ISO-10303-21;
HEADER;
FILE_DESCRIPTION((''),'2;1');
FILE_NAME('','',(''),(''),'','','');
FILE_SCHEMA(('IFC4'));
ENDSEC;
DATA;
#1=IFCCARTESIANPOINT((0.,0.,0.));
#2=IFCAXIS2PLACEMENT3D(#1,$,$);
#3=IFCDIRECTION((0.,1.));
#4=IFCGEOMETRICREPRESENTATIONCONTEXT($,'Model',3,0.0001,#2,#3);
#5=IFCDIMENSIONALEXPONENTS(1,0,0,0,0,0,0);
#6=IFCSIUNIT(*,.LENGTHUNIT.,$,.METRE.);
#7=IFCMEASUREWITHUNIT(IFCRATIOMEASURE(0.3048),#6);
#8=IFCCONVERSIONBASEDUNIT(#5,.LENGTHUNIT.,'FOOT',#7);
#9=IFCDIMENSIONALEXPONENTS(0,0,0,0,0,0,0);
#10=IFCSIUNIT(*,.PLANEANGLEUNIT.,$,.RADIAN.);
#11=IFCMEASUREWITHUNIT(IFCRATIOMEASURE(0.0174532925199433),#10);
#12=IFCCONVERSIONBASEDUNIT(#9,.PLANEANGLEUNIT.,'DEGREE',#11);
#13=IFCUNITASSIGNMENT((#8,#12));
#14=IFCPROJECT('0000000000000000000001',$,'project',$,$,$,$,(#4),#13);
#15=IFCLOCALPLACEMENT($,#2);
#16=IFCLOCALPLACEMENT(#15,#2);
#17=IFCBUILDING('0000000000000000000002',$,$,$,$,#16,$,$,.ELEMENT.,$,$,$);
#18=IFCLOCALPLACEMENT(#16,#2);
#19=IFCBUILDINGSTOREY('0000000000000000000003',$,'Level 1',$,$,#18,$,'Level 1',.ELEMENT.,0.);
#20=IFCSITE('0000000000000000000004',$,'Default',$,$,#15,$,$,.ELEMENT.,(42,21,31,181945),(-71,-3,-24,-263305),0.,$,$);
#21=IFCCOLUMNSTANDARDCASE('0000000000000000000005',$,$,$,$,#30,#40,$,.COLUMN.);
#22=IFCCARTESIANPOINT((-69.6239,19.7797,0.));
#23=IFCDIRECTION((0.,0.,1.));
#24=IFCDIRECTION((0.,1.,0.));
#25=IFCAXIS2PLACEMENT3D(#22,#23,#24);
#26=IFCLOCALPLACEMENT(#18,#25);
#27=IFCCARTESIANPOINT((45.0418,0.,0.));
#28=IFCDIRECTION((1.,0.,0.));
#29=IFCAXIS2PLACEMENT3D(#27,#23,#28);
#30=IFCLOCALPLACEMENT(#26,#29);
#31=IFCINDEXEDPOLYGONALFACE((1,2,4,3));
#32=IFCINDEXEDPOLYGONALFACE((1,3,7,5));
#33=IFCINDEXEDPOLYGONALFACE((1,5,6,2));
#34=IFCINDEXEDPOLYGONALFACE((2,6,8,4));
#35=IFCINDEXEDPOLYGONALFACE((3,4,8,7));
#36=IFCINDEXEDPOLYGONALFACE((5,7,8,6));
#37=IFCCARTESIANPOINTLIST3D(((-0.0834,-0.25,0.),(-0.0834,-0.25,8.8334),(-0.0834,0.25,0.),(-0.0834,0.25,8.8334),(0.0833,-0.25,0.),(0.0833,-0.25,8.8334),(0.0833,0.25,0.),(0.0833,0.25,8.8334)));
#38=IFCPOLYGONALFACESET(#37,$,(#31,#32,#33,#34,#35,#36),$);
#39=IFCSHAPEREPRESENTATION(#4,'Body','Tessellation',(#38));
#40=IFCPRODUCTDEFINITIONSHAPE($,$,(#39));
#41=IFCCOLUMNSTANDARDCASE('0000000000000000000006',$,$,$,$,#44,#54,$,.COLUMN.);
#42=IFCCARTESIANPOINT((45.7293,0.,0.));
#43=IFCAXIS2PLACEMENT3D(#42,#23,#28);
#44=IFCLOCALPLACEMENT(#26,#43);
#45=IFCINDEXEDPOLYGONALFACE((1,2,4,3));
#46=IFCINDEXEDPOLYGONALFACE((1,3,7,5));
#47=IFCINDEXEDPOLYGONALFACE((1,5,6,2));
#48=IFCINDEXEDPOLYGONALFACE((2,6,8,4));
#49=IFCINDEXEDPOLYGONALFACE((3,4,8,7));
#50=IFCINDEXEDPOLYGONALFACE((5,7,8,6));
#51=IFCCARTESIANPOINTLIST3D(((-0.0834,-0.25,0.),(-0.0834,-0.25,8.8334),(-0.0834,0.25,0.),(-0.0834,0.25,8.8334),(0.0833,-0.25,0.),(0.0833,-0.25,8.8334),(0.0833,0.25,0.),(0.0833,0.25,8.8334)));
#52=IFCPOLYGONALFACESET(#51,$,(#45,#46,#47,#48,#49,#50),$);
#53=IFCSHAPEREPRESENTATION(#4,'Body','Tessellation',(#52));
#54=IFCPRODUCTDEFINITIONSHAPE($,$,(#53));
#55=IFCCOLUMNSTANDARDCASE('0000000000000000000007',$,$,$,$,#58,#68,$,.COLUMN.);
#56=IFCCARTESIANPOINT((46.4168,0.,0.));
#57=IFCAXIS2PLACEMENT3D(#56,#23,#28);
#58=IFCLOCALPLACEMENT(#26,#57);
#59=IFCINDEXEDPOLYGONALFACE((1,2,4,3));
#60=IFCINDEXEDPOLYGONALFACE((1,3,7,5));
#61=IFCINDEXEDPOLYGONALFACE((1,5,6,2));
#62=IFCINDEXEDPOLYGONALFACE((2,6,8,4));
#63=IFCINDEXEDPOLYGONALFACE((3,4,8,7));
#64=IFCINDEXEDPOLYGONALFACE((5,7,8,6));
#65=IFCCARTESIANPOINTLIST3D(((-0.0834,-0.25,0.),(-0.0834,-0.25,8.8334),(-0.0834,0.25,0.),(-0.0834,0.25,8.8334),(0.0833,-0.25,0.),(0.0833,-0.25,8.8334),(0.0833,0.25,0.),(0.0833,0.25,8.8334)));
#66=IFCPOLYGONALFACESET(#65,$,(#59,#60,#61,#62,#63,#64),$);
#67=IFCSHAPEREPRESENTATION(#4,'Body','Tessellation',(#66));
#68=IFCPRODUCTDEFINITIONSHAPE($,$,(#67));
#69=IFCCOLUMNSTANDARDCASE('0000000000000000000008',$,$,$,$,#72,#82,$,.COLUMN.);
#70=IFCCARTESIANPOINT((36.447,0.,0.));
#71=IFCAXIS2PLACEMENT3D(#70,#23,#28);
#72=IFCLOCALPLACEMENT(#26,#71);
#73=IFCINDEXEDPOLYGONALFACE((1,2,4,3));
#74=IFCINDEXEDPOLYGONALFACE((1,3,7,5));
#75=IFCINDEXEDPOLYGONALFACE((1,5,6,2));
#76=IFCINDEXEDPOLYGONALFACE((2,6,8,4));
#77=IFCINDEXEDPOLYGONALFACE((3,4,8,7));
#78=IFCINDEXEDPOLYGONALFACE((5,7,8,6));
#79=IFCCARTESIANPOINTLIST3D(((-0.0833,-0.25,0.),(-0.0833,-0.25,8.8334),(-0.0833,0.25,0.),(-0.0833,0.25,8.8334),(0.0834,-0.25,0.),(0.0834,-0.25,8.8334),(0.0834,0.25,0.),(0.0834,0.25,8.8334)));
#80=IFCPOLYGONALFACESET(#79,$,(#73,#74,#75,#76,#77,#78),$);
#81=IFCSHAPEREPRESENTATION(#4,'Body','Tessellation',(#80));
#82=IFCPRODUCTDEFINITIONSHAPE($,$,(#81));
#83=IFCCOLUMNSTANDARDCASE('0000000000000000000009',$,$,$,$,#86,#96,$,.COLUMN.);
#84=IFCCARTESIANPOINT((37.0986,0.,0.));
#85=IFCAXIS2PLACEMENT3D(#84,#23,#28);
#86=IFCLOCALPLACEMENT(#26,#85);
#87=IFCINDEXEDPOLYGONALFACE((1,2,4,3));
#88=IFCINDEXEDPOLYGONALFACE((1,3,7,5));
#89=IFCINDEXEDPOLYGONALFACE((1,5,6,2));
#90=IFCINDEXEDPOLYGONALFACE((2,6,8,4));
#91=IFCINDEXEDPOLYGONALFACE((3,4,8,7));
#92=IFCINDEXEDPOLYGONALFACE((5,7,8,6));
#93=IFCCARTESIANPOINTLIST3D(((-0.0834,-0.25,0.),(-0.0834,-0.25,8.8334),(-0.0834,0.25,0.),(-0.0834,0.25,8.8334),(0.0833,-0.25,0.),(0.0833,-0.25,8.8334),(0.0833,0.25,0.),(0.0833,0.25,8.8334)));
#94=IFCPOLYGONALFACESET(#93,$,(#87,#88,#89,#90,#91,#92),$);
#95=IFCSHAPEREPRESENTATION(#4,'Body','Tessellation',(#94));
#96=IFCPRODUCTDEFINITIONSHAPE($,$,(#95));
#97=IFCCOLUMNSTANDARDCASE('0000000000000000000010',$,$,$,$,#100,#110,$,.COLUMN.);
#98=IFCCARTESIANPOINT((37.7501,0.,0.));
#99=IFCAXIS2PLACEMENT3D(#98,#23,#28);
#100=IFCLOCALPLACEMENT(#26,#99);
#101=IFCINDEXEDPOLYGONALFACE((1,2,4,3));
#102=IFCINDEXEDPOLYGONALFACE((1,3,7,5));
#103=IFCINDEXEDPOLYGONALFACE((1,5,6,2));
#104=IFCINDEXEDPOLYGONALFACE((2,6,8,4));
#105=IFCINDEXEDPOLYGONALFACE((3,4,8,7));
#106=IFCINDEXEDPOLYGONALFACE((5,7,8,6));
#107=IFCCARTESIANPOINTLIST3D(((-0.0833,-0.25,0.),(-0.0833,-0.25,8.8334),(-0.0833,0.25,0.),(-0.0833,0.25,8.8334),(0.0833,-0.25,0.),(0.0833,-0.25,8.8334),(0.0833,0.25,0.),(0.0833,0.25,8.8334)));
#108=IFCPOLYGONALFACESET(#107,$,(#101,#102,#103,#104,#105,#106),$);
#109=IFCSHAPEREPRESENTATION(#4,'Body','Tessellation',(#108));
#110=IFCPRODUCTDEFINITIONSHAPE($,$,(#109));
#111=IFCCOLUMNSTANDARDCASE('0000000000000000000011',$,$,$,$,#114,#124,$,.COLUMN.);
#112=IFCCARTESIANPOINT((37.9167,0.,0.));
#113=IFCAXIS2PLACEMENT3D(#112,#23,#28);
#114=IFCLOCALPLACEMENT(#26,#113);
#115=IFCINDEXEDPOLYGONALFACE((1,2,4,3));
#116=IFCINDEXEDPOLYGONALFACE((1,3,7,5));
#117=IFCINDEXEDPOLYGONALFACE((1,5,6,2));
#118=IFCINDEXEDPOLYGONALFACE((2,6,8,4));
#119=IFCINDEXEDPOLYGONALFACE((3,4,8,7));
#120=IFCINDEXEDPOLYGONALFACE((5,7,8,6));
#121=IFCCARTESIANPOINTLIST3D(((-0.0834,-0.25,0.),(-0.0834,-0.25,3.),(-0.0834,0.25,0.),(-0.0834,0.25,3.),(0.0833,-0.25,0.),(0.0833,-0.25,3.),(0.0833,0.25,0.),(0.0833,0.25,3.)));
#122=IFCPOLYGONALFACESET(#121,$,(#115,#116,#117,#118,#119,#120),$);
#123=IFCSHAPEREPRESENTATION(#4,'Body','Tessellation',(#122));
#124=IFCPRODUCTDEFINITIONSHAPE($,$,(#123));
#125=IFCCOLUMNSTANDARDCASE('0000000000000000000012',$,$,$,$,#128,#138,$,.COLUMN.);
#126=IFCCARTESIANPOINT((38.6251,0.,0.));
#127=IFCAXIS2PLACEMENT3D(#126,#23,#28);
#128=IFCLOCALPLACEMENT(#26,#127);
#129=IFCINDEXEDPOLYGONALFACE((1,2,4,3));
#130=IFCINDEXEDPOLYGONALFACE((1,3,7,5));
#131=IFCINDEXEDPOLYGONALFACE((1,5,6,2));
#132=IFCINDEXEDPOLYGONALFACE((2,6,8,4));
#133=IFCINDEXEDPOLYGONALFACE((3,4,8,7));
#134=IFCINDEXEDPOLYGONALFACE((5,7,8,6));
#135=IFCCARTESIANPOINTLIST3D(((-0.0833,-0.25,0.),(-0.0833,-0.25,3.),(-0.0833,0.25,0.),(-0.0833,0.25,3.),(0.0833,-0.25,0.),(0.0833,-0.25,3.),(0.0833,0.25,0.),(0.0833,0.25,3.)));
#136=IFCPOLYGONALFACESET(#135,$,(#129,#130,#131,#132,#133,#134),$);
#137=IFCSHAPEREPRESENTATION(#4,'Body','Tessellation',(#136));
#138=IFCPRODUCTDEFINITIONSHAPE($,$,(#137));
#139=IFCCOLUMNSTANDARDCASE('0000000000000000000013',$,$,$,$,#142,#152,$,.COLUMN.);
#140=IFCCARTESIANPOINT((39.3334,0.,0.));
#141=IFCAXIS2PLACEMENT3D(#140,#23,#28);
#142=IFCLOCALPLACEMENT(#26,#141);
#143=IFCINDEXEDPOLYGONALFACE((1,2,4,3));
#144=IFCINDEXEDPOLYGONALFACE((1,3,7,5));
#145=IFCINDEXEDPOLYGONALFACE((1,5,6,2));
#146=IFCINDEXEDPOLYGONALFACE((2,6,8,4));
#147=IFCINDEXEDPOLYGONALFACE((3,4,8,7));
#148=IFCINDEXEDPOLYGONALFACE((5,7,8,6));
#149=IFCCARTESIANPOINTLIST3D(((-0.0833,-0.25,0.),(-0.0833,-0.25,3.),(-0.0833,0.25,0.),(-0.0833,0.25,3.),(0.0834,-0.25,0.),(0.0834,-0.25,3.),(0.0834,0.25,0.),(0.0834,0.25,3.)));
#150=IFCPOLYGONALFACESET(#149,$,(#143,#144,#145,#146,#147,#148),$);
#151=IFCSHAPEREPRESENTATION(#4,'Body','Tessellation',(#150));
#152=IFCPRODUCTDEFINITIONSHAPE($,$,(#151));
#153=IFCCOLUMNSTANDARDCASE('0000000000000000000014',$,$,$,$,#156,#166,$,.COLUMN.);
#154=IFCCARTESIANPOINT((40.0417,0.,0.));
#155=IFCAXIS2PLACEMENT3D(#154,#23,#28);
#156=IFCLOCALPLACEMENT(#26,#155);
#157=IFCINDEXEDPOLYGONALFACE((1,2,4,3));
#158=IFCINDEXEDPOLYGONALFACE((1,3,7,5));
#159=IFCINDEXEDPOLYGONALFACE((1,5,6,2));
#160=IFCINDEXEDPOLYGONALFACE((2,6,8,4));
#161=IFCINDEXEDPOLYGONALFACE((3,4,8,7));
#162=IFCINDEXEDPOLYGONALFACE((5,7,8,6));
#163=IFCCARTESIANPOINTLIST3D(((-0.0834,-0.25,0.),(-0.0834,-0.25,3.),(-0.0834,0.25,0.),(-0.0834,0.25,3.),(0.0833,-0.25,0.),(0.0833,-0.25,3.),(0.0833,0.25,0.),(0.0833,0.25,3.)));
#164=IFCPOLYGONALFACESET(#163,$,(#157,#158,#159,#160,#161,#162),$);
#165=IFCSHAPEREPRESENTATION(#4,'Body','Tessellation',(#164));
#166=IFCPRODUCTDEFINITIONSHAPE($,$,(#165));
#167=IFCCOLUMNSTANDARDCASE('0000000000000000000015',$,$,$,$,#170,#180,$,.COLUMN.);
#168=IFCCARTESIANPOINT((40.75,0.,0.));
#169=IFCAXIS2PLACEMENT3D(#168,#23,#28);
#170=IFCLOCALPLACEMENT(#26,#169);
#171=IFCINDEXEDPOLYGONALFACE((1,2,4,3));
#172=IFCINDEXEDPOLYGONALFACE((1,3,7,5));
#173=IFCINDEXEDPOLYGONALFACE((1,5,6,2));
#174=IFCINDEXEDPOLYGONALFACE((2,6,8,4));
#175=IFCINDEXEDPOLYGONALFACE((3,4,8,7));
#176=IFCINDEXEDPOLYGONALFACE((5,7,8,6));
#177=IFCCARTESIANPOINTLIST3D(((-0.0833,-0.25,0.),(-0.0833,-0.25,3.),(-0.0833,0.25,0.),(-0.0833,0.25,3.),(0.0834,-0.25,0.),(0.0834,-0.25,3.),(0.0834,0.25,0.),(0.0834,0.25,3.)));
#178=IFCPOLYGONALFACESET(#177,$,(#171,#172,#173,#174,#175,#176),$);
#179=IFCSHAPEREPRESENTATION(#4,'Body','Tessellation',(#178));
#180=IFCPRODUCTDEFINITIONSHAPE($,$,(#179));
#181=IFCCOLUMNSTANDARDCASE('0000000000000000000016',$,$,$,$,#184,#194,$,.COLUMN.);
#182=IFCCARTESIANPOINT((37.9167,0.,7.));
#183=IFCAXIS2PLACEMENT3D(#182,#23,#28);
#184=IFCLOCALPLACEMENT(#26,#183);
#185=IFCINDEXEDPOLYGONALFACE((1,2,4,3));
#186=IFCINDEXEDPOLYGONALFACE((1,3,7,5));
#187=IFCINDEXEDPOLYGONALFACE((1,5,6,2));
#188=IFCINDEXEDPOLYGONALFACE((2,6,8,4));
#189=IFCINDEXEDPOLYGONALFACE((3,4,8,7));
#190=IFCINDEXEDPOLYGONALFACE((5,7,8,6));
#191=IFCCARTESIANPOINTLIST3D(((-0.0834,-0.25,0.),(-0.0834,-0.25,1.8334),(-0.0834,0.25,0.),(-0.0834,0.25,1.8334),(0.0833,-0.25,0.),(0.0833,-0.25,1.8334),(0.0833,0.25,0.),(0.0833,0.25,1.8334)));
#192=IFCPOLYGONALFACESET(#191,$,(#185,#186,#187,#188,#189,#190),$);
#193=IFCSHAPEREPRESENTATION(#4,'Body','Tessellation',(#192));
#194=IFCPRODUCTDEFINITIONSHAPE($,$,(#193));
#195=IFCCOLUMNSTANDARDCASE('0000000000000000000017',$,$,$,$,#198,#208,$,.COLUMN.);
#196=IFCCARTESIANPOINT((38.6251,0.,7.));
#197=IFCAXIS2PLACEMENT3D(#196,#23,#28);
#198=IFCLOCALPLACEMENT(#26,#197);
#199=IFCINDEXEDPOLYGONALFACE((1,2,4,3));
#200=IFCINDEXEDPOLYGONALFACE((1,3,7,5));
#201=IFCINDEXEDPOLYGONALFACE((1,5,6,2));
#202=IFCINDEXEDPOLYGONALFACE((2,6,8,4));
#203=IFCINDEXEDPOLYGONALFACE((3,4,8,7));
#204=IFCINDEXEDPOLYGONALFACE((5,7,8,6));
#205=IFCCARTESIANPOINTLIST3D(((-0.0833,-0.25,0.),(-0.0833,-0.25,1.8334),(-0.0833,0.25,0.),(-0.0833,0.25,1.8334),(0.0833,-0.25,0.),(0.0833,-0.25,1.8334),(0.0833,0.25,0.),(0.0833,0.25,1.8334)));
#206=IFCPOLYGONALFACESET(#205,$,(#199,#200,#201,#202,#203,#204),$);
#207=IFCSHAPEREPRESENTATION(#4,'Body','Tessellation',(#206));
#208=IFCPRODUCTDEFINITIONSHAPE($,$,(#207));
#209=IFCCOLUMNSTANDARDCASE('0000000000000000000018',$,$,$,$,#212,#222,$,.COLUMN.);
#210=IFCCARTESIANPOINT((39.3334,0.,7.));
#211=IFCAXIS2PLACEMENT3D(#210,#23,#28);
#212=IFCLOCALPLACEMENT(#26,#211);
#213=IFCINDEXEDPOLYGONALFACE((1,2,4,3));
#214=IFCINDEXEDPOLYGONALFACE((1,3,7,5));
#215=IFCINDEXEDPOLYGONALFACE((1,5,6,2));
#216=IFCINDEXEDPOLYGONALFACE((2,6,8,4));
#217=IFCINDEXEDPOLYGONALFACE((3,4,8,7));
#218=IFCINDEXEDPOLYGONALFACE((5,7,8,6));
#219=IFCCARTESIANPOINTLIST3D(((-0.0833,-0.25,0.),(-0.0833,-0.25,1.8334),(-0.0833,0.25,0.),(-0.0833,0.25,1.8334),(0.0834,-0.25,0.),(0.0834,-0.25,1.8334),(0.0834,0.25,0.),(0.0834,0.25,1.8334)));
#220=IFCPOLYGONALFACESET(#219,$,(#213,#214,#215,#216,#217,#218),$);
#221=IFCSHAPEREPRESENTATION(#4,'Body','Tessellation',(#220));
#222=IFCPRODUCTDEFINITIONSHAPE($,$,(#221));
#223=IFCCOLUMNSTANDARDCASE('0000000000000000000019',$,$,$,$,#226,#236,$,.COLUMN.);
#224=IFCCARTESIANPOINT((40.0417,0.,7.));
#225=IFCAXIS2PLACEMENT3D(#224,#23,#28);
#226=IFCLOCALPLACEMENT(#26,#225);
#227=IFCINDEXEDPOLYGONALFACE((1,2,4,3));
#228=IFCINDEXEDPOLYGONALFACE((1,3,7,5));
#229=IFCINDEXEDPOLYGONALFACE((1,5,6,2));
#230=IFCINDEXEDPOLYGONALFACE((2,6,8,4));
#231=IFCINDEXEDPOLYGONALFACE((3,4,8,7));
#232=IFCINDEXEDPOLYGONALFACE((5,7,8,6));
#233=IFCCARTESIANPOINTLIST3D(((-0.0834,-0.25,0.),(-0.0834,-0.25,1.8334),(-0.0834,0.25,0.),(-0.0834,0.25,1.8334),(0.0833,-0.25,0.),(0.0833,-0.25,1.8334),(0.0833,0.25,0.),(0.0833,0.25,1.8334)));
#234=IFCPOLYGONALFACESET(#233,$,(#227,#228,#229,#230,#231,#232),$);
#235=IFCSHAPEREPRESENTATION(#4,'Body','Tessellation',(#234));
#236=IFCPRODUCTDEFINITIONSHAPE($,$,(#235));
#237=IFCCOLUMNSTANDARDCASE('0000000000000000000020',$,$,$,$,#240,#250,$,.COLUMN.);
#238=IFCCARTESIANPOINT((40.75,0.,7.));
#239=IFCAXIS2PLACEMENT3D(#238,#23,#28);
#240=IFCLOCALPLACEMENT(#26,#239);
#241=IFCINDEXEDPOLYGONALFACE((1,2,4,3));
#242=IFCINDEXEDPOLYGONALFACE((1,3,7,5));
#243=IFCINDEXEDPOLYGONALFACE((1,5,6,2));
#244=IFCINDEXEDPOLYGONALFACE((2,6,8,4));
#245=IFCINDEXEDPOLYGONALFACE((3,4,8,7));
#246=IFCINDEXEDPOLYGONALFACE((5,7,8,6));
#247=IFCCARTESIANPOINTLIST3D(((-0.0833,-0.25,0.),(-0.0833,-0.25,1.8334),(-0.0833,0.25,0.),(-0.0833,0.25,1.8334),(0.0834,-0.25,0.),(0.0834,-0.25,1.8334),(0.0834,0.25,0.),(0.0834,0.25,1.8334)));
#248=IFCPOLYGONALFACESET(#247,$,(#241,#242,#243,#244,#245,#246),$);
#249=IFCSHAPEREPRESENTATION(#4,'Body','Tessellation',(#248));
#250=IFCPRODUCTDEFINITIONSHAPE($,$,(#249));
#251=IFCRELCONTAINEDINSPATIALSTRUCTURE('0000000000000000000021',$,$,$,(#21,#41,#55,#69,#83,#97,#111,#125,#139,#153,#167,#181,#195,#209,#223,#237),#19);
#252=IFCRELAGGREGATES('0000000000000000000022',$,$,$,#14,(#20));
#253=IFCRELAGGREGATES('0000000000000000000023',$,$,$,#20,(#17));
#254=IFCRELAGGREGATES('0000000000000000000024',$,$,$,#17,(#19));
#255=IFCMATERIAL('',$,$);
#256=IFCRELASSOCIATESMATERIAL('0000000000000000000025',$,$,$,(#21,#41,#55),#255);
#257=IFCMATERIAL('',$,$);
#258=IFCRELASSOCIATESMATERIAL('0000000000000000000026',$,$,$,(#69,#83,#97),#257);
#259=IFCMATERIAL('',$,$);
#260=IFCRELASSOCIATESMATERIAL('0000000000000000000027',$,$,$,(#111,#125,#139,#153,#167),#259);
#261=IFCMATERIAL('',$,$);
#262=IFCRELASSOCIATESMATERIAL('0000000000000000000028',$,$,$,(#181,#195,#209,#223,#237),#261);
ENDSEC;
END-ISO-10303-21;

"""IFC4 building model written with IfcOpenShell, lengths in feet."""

from ifc_helpers import new_model, entity, si_unit, converted_unit, direction, frame, origin, place, context, project, spatial, rectangle, extrude, material, element, save


model = new_model("IFC4")

# Units and contexts
model_context = context("Model", 3, precision=0.0001, world=origin(), true_north=direction((0.0, 1.0)))
ifc_project = project(units=[converted_unit("LENGTHUNIT", "FOOT", entity("IfcRatioMeasure", 0.3048), si_unit("LENGTHUNIT", "METRE"), dimensions=[1, 0, 0, 0, 0, 0, 0]), converted_unit("PLANEANGLEUNIT", "DEGREE", entity("IfcRatioMeasure", 0.0174532925199433), si_unit("PLANEANGLEUNIT", "RADIAN"), dimensions=[0, 0, 0, 0, 0, 0, 0])], contexts=[model_context])

# Site, building, storey
site_placement = place(None, origin())
site = spatial("IfcSite", under=ifc_project, at=site_placement, Name="Default", CompositionType="ELEMENT", RefLatitude=(42, 21, 31, 181945), RefLongitude=(-71, -3, -24, -263305), RefElevation=0.0)
building_placement = place(site_placement, origin())
building = spatial("IfcBuilding", under=site, at=building_placement, CompositionType="ELEMENT")
storey_placement = place(building_placement, origin())
storey = spatial("IfcBuildingStorey", under=building, at=storey_placement, Name="Level 1", LongName="Level 1", CompositionType="ELEMENT", Elevation=0.0)

# Columns
ifc_material_1 = material(Name="")
placement_1 = place(storey_placement, frame((-69.6239, 19.7797, 0.0), z_axis=(0.0, 0.0, 1.0), x_axis=(0.0, 1.0, 0.0)))
for number, where, z_axis, x_axis in (
    (1, (45.0418, 0.0, 0.0), (0.0, 0.0, 1.0), (1.0, 0.0, 0.0)),
    (2, (45.7293, 0.0, 0.0), (0.0, 0.0, 1.0), (1.0, 0.0, 0.0)),
    (3, (46.4168, 0.0, 0.0), (0.0, 0.0, 1.0), (1.0, 0.0, 0.0)),
):
    element("IfcColumnStandardCase", number, at=place(placement_1, frame(where, z_axis=z_axis, x_axis=x_axis)), inside=storey, material=ifc_material_1, PredefinedType="COLUMN", context=model_context, shape_type="SweptSolid", body=[
        extrude(rectangle(XDim=0.1667, YDim=0.5), origin(), (0.0, 0.0, 1.0), 8.8334),
    ])
ifc_material_2 = material(Name="")
for number, where, z_axis, x_axis in (
    (4, (36.447, 0.0, 0.0), (0.0, 0.0, 1.0), (1.0, 0.0, 0.0)),
    (5, (37.0986, 0.0, 0.0), (0.0, 0.0, 1.0), (1.0, 0.0, 0.0)),
    (6, (37.7501, 0.0, 0.0), (0.0, 0.0, 1.0), (1.0, 0.0, 0.0)),
):
    element("IfcColumnStandardCase", number, at=place(placement_1, frame(where, z_axis=z_axis, x_axis=x_axis)), inside=storey, material=ifc_material_2, PredefinedType="COLUMN", context=model_context, shape_type="SweptSolid", body=[
        extrude(rectangle(XDim=0.1667, YDim=0.5), origin(), (0.0, 0.0, 1.0), 8.8334),
    ])
ifc_material_3 = material(Name="")
for number, where, z_axis, x_axis in (
    (7, (37.9167, 0.0, 0.0), (0.0, 0.0, 1.0), (1.0, 0.0, 0.0)),
    (8, (38.6251, 0.0, 0.0), (0.0, 0.0, 1.0), (1.0, 0.0, 0.0)),
    (9, (39.3334, 0.0, 0.0), (0.0, 0.0, 1.0), (1.0, 0.0, 0.0)),
    (10, (40.0417, 0.0, 0.0), (0.0, 0.0, 1.0), (1.0, 0.0, 0.0)),
    (11, (40.75, 0.0, 0.0), (0.0, 0.0, 1.0), (1.0, 0.0, 0.0)),
):
    element("IfcColumnStandardCase", number, at=place(placement_1, frame(where, z_axis=z_axis, x_axis=x_axis)), inside=storey, material=ifc_material_3, PredefinedType="COLUMN", context=model_context, shape_type="SweptSolid", body=[
        extrude(rectangle(XDim=0.1667, YDim=0.5), origin(), (0.0, 0.0, 1.0), 3.0),
    ])
ifc_material_4 = material(Name="")
for number, where, z_axis, x_axis in (
    (12, (37.9167, 0.0, 7.0), (0.0, 0.0, 1.0), (1.0, 0.0, 0.0)),
    (13, (38.6251, 0.0, 7.0), (0.0, 0.0, 1.0), (1.0, 0.0, 0.0)),
    (14, (39.3334, 0.0, 7.0), (0.0, 0.0, 1.0), (1.0, 0.0, 0.0)),
    (15, (40.0417, 0.0, 7.0), (0.0, 0.0, 1.0), (1.0, 0.0, 0.0)),
    (16, (40.75, 0.0, 7.0), (0.0, 0.0, 1.0), (1.0, 0.0, 0.0)),
):
    element("IfcColumnStandardCase", number, at=place(placement_1, frame(where, z_axis=z_axis, x_axis=x_axis)), inside=storey, material=ifc_material_4, PredefinedType="COLUMN", context=model_context, shape_type="SweptSolid", body=[
        extrude(rectangle(XDim=0.1667, YDim=0.5), origin(), (0.0, 0.0, 1.0), 1.8334),
    ])

save(model, "model.ifc")
